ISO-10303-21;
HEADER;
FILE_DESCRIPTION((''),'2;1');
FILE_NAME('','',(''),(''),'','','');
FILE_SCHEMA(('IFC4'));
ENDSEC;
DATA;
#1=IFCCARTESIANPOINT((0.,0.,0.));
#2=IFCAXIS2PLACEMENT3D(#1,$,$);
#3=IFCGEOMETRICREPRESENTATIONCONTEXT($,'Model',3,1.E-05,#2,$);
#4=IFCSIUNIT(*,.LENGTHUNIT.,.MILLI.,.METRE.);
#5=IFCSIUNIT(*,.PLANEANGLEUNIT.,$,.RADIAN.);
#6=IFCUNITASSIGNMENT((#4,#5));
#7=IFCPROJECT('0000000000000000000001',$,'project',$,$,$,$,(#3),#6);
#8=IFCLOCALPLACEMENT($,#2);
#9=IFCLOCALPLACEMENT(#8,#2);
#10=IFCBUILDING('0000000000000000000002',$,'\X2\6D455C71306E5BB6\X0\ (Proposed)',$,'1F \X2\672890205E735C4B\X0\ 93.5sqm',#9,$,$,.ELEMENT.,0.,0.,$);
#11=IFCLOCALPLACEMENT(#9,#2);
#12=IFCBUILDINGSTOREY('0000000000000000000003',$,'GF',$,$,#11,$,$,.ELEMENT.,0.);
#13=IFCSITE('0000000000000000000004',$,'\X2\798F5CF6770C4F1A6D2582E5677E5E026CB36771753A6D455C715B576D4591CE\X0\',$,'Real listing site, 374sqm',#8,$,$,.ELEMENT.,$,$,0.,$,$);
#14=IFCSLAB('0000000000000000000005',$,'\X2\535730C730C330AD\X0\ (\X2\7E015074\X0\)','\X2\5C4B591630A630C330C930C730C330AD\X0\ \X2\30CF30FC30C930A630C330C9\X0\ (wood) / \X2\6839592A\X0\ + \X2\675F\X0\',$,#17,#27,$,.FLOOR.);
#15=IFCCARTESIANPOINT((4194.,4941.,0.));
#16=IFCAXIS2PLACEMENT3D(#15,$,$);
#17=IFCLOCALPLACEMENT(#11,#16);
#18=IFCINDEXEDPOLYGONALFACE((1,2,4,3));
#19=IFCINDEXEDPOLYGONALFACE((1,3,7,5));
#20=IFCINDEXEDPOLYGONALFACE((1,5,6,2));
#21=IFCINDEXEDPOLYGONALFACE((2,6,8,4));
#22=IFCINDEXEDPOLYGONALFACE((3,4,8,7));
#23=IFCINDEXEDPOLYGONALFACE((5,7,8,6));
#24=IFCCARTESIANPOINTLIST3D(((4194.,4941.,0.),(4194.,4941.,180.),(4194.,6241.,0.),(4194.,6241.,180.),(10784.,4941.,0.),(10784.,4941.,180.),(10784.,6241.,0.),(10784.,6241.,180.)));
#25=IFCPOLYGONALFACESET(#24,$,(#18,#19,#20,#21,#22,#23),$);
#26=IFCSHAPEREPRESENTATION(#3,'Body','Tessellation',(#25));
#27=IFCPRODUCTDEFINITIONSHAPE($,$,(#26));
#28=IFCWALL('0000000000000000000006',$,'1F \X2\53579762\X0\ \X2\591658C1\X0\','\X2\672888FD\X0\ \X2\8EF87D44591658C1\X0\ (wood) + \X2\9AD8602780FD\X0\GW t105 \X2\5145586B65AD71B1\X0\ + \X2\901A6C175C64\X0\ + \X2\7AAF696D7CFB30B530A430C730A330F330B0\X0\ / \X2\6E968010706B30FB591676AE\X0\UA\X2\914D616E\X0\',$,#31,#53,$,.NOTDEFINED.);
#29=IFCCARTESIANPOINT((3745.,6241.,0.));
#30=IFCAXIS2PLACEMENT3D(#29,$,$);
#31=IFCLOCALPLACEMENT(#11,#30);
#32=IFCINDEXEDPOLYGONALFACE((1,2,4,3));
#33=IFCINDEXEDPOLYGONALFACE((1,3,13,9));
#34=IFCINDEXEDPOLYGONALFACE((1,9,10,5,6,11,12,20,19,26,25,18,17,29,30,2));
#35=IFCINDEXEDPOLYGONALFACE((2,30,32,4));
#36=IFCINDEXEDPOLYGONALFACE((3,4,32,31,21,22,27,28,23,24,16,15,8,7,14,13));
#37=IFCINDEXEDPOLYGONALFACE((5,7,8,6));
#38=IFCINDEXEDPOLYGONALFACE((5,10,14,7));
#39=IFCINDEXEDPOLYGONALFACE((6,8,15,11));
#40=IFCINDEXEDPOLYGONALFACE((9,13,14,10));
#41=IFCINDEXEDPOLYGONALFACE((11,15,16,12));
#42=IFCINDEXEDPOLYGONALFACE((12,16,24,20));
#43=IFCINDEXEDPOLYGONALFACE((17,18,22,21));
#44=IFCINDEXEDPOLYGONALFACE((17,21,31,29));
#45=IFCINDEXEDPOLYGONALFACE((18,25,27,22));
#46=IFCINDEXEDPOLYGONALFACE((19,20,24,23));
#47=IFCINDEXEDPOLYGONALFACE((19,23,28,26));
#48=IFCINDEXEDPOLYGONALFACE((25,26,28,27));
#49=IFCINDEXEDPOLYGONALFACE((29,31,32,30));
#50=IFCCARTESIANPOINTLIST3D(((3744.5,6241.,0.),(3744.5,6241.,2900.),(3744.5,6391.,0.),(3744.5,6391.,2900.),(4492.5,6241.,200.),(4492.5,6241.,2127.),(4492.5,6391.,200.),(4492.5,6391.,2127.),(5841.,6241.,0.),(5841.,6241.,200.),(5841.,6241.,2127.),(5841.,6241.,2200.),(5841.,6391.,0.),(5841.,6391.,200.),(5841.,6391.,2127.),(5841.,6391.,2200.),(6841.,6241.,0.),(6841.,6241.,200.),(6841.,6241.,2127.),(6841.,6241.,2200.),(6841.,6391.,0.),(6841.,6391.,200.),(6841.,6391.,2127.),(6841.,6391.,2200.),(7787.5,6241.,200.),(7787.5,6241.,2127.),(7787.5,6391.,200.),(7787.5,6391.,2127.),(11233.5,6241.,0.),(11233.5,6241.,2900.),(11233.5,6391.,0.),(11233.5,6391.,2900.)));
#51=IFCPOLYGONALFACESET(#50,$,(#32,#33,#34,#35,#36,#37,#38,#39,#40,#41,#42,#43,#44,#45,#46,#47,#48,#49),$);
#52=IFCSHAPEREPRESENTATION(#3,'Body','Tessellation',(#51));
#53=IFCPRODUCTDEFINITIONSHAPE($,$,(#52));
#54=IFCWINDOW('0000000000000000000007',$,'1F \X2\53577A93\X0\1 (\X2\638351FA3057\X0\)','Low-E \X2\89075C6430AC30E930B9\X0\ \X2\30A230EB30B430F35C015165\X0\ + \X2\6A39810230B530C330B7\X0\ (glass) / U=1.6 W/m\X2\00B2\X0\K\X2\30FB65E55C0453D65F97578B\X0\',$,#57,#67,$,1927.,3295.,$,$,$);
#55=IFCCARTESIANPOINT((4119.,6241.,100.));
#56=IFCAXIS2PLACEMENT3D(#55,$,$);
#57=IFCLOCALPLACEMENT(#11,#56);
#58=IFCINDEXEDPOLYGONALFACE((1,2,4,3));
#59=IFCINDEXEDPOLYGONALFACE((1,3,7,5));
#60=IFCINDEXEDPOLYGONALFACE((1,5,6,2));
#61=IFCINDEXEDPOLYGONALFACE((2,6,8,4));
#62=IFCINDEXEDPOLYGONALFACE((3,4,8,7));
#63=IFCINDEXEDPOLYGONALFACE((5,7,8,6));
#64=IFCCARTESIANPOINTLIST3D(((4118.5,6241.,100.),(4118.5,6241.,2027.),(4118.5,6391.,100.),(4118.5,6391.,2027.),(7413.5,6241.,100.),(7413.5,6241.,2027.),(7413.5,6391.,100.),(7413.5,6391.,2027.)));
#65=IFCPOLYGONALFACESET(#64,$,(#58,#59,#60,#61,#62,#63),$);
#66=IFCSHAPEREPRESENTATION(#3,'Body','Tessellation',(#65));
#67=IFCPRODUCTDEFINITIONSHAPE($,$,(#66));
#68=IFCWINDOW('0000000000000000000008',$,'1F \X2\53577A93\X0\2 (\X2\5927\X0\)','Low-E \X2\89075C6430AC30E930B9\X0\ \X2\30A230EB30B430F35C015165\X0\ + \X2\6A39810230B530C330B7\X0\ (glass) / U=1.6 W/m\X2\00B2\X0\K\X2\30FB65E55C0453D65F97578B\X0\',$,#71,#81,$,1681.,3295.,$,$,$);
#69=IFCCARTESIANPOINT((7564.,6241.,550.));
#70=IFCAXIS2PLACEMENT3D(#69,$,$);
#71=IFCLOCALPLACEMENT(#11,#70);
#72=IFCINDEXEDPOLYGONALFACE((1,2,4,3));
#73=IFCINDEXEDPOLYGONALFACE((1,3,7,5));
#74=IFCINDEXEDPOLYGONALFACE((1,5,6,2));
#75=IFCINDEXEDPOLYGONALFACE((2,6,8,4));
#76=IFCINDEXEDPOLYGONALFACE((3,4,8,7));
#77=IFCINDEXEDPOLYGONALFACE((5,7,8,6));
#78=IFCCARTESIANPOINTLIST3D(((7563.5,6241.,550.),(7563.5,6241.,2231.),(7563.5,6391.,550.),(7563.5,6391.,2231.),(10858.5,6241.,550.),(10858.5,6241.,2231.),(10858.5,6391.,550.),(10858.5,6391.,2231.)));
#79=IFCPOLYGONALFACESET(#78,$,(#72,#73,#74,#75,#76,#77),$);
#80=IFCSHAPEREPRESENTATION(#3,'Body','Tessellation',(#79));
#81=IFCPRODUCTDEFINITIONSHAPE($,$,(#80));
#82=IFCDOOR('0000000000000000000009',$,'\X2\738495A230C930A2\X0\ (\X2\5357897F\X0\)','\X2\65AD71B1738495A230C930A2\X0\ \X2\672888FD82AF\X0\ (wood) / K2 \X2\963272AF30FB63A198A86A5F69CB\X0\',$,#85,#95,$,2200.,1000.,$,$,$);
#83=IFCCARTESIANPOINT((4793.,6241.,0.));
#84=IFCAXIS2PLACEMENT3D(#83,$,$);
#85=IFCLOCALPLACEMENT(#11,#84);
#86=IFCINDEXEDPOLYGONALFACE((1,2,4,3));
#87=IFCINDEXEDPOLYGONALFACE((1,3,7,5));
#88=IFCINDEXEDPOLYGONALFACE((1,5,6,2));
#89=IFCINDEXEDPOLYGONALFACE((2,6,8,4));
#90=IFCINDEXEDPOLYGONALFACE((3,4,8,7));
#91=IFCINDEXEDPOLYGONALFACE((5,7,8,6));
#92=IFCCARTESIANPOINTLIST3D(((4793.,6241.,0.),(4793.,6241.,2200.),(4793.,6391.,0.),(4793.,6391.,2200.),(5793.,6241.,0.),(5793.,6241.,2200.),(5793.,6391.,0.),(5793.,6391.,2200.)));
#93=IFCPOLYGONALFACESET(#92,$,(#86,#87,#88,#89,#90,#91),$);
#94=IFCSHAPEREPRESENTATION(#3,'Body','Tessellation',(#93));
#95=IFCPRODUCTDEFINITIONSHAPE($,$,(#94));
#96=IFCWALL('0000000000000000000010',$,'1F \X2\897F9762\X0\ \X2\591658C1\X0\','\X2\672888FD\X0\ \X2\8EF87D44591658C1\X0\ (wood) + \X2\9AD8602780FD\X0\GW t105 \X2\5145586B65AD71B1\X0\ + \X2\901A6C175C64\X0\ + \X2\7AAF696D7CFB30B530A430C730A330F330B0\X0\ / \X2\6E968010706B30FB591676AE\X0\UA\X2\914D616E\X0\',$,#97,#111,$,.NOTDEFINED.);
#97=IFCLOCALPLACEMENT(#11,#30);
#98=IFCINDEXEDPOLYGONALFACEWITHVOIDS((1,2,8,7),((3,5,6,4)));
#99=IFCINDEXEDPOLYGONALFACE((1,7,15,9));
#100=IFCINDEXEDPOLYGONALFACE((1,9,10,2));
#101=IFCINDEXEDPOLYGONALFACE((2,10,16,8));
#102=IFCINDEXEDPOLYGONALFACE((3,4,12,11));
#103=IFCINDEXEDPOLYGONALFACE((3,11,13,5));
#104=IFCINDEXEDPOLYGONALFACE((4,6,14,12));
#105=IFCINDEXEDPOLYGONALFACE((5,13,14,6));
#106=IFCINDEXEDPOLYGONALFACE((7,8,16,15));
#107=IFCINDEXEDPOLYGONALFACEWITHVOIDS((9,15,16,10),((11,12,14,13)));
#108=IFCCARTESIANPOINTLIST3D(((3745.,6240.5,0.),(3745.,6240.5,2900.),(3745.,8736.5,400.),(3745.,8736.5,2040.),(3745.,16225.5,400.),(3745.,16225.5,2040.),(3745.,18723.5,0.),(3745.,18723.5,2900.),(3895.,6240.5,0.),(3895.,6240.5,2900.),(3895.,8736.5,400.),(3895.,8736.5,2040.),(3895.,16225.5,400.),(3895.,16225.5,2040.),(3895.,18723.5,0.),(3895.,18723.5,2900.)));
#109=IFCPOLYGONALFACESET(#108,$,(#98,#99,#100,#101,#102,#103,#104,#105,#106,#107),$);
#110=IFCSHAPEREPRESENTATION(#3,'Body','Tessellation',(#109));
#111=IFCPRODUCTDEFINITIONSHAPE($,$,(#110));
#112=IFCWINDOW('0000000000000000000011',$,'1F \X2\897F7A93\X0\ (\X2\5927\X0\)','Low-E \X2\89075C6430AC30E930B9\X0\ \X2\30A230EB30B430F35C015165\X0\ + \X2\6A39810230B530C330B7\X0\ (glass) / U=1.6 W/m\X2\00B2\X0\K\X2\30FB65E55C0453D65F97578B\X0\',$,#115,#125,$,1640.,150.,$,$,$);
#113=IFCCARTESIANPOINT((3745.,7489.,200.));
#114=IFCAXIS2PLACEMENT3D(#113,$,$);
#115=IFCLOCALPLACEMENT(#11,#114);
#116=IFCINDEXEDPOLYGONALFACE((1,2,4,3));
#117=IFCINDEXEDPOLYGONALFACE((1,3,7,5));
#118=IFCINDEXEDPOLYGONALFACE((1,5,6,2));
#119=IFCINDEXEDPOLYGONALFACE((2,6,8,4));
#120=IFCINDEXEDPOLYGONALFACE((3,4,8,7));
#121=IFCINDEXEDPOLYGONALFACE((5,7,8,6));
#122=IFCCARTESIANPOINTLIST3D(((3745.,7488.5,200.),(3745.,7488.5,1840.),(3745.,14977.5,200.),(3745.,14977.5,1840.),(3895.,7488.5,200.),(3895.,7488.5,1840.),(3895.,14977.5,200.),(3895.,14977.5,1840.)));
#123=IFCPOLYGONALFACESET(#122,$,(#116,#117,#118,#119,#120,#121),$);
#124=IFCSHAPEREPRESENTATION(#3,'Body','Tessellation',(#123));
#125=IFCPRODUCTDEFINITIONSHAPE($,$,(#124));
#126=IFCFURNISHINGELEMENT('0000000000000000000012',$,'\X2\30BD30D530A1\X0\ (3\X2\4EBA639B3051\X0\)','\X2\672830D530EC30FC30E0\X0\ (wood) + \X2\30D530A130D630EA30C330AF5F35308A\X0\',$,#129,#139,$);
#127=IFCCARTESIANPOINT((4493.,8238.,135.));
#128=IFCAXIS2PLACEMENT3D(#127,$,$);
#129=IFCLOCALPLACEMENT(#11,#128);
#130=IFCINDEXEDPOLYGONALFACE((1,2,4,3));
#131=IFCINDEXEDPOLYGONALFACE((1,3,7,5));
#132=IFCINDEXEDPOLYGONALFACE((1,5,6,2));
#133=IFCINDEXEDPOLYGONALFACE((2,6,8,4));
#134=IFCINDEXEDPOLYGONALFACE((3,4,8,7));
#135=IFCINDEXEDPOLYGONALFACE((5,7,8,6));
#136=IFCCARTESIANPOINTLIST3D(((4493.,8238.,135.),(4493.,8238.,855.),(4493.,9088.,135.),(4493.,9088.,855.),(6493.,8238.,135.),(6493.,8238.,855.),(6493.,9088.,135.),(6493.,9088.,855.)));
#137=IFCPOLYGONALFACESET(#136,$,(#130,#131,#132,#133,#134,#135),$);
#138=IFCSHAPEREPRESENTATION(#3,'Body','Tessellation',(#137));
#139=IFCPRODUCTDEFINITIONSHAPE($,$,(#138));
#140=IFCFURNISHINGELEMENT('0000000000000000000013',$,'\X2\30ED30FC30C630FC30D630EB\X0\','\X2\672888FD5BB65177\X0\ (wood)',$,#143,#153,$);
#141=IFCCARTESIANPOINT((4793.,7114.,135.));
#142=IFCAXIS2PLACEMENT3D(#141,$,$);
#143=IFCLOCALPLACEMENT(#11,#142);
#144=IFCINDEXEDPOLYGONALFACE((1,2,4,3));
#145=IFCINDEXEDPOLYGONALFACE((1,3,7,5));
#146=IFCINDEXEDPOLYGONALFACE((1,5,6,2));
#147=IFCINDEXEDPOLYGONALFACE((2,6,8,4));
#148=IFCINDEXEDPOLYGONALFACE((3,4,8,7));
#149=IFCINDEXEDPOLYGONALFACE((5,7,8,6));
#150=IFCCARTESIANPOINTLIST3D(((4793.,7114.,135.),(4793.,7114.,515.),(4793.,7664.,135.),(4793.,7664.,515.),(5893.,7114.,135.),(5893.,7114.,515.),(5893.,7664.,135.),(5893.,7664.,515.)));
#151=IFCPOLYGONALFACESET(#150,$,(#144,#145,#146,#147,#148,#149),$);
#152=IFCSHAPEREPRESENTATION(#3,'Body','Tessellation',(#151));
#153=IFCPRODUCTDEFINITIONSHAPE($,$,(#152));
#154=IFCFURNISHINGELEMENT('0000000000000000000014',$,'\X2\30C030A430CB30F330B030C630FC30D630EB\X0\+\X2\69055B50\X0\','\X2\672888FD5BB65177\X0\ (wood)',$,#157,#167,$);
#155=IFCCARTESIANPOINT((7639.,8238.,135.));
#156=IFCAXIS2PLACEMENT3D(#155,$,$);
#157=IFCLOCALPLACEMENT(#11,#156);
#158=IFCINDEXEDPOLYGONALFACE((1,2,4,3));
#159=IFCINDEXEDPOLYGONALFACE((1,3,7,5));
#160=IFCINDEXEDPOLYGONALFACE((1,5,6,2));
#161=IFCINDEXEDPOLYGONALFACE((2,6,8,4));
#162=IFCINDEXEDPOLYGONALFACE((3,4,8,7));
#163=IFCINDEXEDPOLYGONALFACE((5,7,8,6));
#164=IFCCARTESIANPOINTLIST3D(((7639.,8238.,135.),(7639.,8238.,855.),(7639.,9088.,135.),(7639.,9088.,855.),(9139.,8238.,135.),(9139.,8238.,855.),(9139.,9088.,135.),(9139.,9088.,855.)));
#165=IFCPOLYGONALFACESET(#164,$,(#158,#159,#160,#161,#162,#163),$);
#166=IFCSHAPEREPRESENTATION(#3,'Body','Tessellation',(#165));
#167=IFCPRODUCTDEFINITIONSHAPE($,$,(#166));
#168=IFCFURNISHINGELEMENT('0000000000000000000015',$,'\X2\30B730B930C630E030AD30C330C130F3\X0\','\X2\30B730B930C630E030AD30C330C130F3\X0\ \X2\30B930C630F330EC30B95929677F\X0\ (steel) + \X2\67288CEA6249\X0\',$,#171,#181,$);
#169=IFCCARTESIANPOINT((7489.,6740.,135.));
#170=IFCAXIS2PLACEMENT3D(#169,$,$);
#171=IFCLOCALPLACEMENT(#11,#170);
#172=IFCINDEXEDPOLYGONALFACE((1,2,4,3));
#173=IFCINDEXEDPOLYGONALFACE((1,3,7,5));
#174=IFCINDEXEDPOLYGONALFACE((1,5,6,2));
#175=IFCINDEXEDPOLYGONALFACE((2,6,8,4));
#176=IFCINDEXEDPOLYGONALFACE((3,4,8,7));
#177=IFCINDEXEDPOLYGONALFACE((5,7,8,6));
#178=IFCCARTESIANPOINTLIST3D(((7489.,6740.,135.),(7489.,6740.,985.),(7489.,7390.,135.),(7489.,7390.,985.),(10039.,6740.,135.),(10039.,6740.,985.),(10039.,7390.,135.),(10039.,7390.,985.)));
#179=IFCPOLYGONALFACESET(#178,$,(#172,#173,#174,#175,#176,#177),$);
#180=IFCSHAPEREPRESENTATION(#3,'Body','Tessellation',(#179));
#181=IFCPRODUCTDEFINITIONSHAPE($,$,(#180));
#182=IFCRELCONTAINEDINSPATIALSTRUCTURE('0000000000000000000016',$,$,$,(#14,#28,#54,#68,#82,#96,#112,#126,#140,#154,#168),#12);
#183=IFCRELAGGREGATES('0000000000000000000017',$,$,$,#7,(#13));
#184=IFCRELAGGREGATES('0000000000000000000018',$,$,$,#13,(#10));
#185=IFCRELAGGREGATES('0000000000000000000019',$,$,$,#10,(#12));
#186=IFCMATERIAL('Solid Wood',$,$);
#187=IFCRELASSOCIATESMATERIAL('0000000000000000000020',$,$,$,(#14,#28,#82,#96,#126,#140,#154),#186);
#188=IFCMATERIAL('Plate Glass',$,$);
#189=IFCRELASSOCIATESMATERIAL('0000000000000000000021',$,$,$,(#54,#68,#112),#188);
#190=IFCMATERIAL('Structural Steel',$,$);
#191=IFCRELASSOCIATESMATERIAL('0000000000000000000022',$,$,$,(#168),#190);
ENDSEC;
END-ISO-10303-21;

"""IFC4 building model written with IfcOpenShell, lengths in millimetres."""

from ifc_helpers import new_model, si_unit, frame, frame_2d, origin, place, context, project, spatial, rectangle, extrude, material, element, fill, save


model = new_model("IFC4")

# Units and contexts
model_context = context("Model", 3, precision=1e-05, world=origin())
ifc_project = project(units=[si_unit("LENGTHUNIT", "METRE", prefix="MILLI"), si_unit("PLANEANGLEUNIT", "RADIAN")], contexts=[model_context])

# Site, building, storey
site_placement = place(None, origin())
site = spatial("IfcSite", under=ifc_project, at=site_placement, Name="福島県会津若松市河東町浅山字浅野", ObjectType="Real listing site, 374sqm", CompositionType="ELEMENT", RefElevation=0.0)
building_placement = place(site_placement, origin())
building = spatial("IfcBuilding", under=site, at=building_placement, Name="浅山の家 (Proposed)", ObjectType="1F 木造平屋 93.5sqm", CompositionType="ELEMENT", ElevationOfRefHeight=0.0, ElevationOfTerrain=0.0)
storey_placement = place(building_placement, origin())
storey = spatial("IfcBuildingStorey", under=building, at=storey_placement, Name="GF", CompositionType="ELEMENT", Elevation=0.0)

# Slab
ifc_material_1 = material(Name="Solid Wood")
slab_1_placement = place(storey_placement, frame((4194.0, 4941.0, 0.0)))
element("IfcSlab", 1, at=slab_1_placement, inside=storey, material=ifc_material_1, Name="南デッキ (縁側)", Description="屋外ウッドデッキ ハードウッド (wood) / 根太 + 束", PredefinedType="FLOOR", context=model_context, shape_type="SweptSolid", body=[
    extrude(rectangle(XDim=6590.0, YDim=1300.0, at=frame_2d((3295.0, 650.0))), frame((4194.0, 4941.0, 0.0)), (0.0, 0.0, 1.0), 180.0),
])

# Wall, openings, windows, door
wall_1_placement = place(storey_placement, frame((3745.0, 6241.0, 0.0)))
wall_1 = element("IfcWall", 2, at=wall_1_placement, inside=storey, material=ifc_material_1, Name="1F 南面 外壁", Description="木製 軸組外壁 (wood) + 高性能GW t105 充填断熱 + 通気層 + 窯業系サイディング / 準耐火・外皮UA配慮", PredefinedType="NOTDEFINED", context=model_context, shape_type="SweptSolid", body=[
    extrude(rectangle(XDim=7489.0, YDim=150.0, at=frame_2d((3744.0, 75.0))), frame((3745.0, 6241.0, 0.0)), (0.0, 0.0, 1.0), 2900.0),
])
opening_1_placement = place(storey_placement, frame((4119.0, 6241.0, 100.0)))
opening_1 = element("IfcOpeningElement", 3, at=opening_1_placement, cuts=wall_1, PredefinedType="NOTDEFINED", context=model_context, shape_type="SweptSolid", body=[
    extrude(rectangle(XDim=3295.0, YDim=150.0, at=frame_2d((1647.0, 75.0))), frame((4119.0, 6241.0, 100.0)), (0.0, 0.0, 1.0), 1927.0),
])
opening_2_placement = place(storey_placement, frame((7564.0, 6241.0, 550.0)))
opening_2 = element("IfcOpeningElement", 4, at=opening_2_placement, cuts=wall_1, PredefinedType="NOTDEFINED", context=model_context, shape_type="SweptSolid", body=[
    extrude(rectangle(XDim=3295.0, YDim=150.0, at=frame_2d((1647.0, 75.0))), frame((7564.0, 6241.0, 550.0)), (0.0, 0.0, 1.0), 1681.0),
])
opening_3_placement = place(storey_placement, frame((4793.0, 6241.0, 0.0)))
opening_3 = element("IfcOpeningElement", 5, at=opening_3_placement, cuts=wall_1, PredefinedType="NOTDEFINED", context=model_context, shape_type="SweptSolid", body=[
    extrude(rectangle(XDim=1000.0, YDim=150.0, at=frame_2d((500.0, 75.0))), frame((4793.0, 6241.0, 0.0)), (0.0, 0.0, 1.0), 2200.0),
])
ifc_material_2 = material(Name="Plate Glass")
window_1_placement = place(storey_placement, frame((4119.0, 6241.0, 100.0)))
window_1 = element("IfcWindow", 6, at=window_1_placement, inside=storey, material=ifc_material_2, Name="1F 南窓1 (掃出し)", Description="Low-E 複層ガラス アルゴン封入 + 樹脂サッシ (glass) / U=1.6 W/m²K・日射取得型", OverallHeight=1927.0, OverallWidth=3295.0, context=model_context, shape_type="SweptSolid", body=[
    extrude(rectangle(XDim=3295.0, YDim=150.0, at=frame_2d((1647.0, 75.0))), frame((4119.0, 6241.0, 100.0)), (0.0, 0.0, 1.0), 1927.0),
])
fill(opening_1, window_1)
window_2_placement = place(storey_placement, frame((7564.0, 6241.0, 550.0)))
window_2 = element("IfcWindow", 7, at=window_2_placement, inside=storey, material=ifc_material_2, Name="1F 南窓2 (大)", Description="Low-E 複層ガラス アルゴン封入 + 樹脂サッシ (glass) / U=1.6 W/m²K・日射取得型", OverallHeight=1681.0, OverallWidth=3295.0, context=model_context, shape_type="SweptSolid", body=[
    extrude(rectangle(XDim=3295.0, YDim=150.0, at=frame_2d((1647.0, 75.0))), frame((7564.0, 6241.0, 550.0)), (0.0, 0.0, 1.0), 1681.0),
])
fill(opening_2, window_2)
door_placement = place(storey_placement, frame((4793.0, 6241.0, 0.0)))
door = element("IfcDoor", 8, at=door_placement, inside=storey, material=ifc_material_1, Name="玄関ドア (南西)", Description="断熱玄関ドア 木製芯 (wood) / K2 防犯・採風機構", OverallHeight=2200.0, OverallWidth=1000.0, context=model_context, shape_type="SweptSolid", body=[
    extrude(rectangle(XDim=1000.0, YDim=150.0, at=frame_2d((500.0, 75.0))), frame((4793.0, 6241.0, 0.0)), (0.0, 0.0, 1.0), 2200.0),
])
fill(opening_3, door)

# Wall, opening, window
wall_2_placement = place(storey_placement, frame((3745.0, 6241.0, 0.0)))
wall_2 = element("IfcWall", 9, at=wall_2_placement, inside=storey, material=ifc_material_1, Name="1F 西面 外壁", Description="木製 軸組外壁 (wood) + 高性能GW t105 充填断熱 + 通気層 + 窯業系サイディング / 準耐火・外皮UA配慮", PredefinedType="NOTDEFINED", context=model_context, shape_type="SweptSolid", body=[
    extrude(rectangle(XDim=150.0, YDim=12483.0, at=frame_2d((75.0, 6241.0))), frame((3745.0, 6241.0, 0.0)), (0.0, 0.0, 1.0), 2900.0),
])
opening_4_placement = place(storey_placement, frame((3745.0, 7489.0, 200.0)))
opening_4 = element("IfcOpeningElement", 10, at=opening_4_placement, cuts=wall_2, PredefinedType="NOTDEFINED", context=model_context, shape_type="SweptSolid", body=[
    extrude(rectangle(XDim=150.0, YDim=7489.0, at=frame_2d((75.0, 3744.0))), frame((3745.0, 7489.0, 200.0)), (0.0, 0.0, 1.0), 1640.0),
])
window_3_placement = place(storey_placement, frame((3745.0, 7489.0, 200.0)))
window_3 = element("IfcWindow", 11, at=window_3_placement, inside=storey, material=ifc_material_2, Name="1F 西窓 (大)", Description="Low-E 複層ガラス アルゴン封入 + 樹脂サッシ (glass) / U=1.6 W/m²K・日射取得型", OverallHeight=1640.0, OverallWidth=150.0, context=model_context, shape_type="SweptSolid", body=[
    extrude(rectangle(XDim=150.0, YDim=7489.0, at=frame_2d((75.0, 3744.0))), frame((3745.0, 7489.0, 200.0)), (0.0, 0.0, 1.0), 1640.0),
])
fill(opening_4, window_3)

# Shared definitions
ifc_material_3 = material(Name="Structural Steel")

# Furnishing elements
furnishing_1_placement = place(storey_placement, frame((4493.0, 8238.0, 135.0)))
element("IfcFurnishingElement", 12, at=furnishing_1_placement, inside=storey, material=ifc_material_1, Name="ソファ (3人掛け)", Description="木フレーム (wood) + ファブリック張り", context=model_context, shape_type="SweptSolid", body=[
    extrude(rectangle(XDim=2000.0, YDim=850.0, at=frame_2d((1000.0, 425.0))), frame((4493.0, 8238.0, 135.0)), (0.0, 0.0, 1.0), 720.0),
])
furnishing_2_placement = place(storey_placement, frame((4793.0, 7114.0, 135.0)))
element("IfcFurnishingElement", 13, at=furnishing_2_placement, inside=storey, material=ifc_material_1, Name="ローテーブル", Description="木製家具 (wood)", context=model_context, shape_type="SweptSolid", body=[
    extrude(rectangle(XDim=1100.0, YDim=550.0, at=frame_2d((550.0, 275.0))), frame((4793.0, 7114.0, 135.0)), (0.0, 0.0, 1.0), 380.0),
])
furnishing_3_placement = place(storey_placement, frame((7639.0, 8238.0, 135.0)))
element("IfcFurnishingElement", 14, at=furnishing_3_placement, inside=storey, material=ifc_material_1, Name="ダイニングテーブル+椅子", Description="木製家具 (wood)", context=model_context, shape_type="SweptSolid", body=[
    extrude(rectangle(XDim=1500.0, YDim=850.0, at=frame_2d((750.0, 425.0))), frame((7639.0, 8238.0, 135.0)), (0.0, 0.0, 1.0), 720.0),
])
furnishing_4_placement = place(storey_placement, frame((7489.0, 6740.0, 135.0)))
element("IfcFurnishingElement", 15, at=furnishing_4_placement, inside=storey, material=ifc_material_3, Name="システムキッチン", Description="システムキッチン ステンレス天板 (steel) + 木質扉", context=model_context, shape_type="SweptSolid", body=[
    extrude(rectangle(XDim=2550.0, YDim=650.0, at=frame_2d((1275.0, 325.0))), frame((7489.0, 6740.0, 135.0)), (0.0, 0.0, 1.0), 850.0),
])

save(model, "model.ifc")
